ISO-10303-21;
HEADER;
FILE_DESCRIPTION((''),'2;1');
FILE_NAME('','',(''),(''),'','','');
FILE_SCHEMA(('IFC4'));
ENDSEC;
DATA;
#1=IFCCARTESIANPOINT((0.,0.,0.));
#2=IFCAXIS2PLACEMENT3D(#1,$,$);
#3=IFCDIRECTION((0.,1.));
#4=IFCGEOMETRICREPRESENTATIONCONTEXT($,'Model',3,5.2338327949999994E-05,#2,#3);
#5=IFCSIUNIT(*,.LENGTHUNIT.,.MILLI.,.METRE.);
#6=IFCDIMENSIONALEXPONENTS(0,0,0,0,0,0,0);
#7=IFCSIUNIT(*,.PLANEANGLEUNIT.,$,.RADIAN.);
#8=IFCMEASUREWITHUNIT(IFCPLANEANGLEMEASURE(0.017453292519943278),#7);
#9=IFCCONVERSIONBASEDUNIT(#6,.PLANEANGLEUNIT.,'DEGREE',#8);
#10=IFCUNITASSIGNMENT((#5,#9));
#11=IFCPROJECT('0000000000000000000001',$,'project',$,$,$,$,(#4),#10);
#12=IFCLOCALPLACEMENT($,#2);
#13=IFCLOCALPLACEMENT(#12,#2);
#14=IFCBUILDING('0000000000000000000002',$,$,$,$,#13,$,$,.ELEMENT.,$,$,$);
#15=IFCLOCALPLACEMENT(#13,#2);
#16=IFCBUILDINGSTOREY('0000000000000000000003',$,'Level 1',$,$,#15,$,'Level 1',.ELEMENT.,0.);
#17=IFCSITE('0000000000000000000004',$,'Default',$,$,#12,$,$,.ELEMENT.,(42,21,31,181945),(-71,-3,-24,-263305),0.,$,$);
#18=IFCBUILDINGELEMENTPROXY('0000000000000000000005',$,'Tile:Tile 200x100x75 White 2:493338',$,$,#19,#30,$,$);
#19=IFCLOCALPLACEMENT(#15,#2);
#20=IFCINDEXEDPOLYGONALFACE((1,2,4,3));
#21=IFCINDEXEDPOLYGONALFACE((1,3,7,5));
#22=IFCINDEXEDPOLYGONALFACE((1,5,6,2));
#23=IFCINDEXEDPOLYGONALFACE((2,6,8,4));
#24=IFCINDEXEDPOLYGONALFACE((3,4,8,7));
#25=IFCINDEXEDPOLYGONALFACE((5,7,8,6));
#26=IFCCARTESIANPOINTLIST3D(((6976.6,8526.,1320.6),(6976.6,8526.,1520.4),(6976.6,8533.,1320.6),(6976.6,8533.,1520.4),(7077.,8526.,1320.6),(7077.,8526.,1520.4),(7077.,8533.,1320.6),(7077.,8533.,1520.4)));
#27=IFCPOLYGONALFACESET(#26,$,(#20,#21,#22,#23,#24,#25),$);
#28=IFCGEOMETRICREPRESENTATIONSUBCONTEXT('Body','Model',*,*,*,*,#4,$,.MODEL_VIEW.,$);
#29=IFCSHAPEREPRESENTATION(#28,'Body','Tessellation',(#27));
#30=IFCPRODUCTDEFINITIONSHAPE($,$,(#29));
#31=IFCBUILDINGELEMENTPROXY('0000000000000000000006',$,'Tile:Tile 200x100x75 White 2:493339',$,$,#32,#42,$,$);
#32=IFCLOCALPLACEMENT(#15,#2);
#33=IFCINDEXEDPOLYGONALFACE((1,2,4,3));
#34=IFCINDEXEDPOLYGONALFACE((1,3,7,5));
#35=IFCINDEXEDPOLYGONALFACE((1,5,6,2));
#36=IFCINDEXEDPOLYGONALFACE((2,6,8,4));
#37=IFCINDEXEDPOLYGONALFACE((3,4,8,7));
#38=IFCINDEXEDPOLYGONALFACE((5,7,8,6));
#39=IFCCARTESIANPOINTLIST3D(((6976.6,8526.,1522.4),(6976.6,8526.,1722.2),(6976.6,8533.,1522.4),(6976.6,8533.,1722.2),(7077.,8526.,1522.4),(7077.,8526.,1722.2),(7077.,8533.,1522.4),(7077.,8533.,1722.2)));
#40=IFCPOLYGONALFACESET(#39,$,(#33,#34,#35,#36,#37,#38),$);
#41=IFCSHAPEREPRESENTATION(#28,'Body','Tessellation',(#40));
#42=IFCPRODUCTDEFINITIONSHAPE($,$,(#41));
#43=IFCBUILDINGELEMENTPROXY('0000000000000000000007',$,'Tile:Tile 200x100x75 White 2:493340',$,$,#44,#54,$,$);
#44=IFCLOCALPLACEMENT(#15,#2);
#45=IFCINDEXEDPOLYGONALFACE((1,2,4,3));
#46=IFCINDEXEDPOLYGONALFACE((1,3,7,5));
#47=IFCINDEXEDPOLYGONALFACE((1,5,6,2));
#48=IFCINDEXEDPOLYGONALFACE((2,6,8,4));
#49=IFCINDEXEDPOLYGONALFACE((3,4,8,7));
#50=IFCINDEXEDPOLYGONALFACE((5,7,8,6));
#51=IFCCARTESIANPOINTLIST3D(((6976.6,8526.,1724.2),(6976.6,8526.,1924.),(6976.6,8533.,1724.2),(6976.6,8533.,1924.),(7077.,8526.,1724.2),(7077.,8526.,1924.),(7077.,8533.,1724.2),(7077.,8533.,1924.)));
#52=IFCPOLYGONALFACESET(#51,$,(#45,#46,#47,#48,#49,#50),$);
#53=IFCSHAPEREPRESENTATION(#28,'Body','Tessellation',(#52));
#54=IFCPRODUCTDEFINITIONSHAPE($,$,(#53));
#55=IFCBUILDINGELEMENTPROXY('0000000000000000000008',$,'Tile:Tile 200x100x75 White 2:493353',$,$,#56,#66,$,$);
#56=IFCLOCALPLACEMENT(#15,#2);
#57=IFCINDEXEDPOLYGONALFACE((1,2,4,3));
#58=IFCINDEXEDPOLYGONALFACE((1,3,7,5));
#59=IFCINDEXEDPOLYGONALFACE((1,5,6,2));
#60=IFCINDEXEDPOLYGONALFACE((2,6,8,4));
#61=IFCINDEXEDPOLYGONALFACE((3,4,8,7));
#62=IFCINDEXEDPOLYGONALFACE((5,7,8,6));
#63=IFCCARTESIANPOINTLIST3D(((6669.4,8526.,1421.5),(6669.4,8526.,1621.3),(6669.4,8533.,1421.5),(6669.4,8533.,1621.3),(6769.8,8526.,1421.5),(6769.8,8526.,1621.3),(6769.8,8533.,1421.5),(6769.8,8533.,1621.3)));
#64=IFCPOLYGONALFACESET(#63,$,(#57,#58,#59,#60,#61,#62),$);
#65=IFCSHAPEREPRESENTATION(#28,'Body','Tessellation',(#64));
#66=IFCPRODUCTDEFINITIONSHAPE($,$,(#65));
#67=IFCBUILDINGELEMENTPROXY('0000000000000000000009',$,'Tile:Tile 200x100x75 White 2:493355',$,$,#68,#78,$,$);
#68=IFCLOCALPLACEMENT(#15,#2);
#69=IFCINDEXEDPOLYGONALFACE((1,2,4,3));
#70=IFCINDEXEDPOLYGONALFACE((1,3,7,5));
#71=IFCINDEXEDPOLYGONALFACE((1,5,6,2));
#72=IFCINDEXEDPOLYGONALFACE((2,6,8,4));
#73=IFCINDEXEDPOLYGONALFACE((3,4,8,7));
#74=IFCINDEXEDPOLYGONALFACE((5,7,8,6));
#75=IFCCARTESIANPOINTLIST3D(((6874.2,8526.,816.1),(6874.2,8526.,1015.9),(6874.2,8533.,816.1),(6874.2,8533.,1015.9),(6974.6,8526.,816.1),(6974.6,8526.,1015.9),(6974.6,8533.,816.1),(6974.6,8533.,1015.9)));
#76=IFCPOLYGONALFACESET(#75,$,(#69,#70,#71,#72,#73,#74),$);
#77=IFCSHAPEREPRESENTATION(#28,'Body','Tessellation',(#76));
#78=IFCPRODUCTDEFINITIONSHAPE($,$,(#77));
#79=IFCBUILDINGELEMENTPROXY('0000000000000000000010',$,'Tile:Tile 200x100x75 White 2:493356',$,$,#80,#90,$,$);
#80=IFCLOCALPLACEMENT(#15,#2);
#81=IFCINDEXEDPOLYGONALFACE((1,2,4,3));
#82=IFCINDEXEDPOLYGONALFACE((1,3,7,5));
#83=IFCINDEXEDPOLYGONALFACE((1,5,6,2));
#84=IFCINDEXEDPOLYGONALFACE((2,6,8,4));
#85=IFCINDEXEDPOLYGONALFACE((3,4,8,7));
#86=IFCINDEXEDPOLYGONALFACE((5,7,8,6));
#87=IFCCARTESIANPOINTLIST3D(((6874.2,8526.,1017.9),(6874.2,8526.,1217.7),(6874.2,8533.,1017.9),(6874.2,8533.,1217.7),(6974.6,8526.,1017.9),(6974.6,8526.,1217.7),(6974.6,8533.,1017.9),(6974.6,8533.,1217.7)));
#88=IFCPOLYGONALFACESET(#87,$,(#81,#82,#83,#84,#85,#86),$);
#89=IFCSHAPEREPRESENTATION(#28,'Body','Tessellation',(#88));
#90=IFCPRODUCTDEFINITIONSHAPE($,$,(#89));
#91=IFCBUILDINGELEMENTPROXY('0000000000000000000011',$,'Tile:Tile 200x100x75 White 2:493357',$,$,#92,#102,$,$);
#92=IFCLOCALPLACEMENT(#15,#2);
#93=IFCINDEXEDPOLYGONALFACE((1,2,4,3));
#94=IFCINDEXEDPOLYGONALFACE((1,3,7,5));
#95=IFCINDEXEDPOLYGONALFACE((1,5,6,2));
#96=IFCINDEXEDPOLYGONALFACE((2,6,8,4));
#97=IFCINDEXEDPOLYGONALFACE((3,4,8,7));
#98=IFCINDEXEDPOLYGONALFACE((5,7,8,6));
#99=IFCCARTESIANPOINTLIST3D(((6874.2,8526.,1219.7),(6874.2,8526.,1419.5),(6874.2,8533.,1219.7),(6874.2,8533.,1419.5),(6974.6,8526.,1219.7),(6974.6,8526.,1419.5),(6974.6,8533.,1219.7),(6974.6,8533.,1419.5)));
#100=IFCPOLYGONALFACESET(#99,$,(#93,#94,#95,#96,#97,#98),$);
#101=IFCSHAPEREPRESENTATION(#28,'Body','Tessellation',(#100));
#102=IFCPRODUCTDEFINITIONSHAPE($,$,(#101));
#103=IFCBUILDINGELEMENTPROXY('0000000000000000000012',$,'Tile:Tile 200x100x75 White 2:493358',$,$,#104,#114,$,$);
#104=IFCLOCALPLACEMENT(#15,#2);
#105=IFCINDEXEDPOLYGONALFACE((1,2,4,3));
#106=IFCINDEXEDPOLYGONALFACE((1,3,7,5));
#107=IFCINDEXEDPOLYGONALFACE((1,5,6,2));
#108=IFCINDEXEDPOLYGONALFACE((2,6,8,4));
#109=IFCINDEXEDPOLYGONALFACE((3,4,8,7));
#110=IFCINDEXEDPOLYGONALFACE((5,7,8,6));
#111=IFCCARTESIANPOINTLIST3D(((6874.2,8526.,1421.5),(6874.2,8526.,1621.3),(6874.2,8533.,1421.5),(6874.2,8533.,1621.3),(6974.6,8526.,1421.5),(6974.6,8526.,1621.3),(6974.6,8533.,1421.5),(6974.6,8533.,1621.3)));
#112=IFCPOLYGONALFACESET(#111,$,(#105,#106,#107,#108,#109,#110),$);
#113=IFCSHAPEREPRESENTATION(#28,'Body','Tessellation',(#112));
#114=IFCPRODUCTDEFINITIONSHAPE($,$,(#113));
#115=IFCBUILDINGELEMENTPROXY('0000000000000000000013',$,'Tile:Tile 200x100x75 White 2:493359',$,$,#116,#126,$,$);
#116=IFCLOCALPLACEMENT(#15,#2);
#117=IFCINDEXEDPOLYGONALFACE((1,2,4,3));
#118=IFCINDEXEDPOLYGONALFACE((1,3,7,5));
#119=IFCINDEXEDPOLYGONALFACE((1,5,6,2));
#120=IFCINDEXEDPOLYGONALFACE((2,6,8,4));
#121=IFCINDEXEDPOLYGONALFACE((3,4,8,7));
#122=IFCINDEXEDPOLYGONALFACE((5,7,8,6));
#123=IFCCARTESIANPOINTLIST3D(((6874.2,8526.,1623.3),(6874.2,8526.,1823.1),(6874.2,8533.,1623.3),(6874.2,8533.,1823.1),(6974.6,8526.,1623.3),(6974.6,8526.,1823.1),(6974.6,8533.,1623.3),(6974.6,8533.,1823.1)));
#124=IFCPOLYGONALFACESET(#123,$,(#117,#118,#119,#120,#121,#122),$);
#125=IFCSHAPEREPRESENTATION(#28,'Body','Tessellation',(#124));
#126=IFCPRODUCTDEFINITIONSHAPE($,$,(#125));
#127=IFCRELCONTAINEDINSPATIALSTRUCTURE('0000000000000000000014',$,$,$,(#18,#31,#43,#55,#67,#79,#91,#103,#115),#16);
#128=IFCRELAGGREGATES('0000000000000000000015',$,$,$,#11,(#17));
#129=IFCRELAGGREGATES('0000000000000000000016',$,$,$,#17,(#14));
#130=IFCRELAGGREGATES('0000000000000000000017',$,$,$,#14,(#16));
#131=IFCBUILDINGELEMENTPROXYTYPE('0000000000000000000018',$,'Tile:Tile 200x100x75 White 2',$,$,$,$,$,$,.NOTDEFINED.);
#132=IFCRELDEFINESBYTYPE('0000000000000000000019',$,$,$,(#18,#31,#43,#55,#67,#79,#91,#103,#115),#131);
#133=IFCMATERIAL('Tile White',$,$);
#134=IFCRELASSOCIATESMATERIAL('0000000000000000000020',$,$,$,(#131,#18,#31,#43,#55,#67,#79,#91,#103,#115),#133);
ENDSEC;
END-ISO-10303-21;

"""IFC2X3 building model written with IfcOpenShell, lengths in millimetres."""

from ifc_helpers import new_model, entity, si_unit, converted_unit, direction, frame, frame_2d, origin, place, context, subcontext, project, spatial, rectangle, extrude, source, transform, mapped, material, type_object, type_shapes, element, save


model = new_model("IFC2X3")

# Units and contexts
model_context = context("Model", 3, precision=5.2338327949999994e-05, world=origin(), true_north=direction((0.0, 1.0)))
body_context = subcontext(model_context, "Body", "Model", "MODEL_VIEW")
ifc_project = project(units=[si_unit("LENGTHUNIT", "METRE", prefix="MILLI"), converted_unit("PLANEANGLEUNIT", "DEGREE", entity("IfcPlaneAngleMeasure", 0.017453292519943278), si_unit("PLANEANGLEUNIT", "RADIAN"), dimensions=[0, 0, 0, 0, 0, 0, 0])], contexts=[model_context])

# Site, building, storey
site_placement = place(None, origin())
site = spatial("IfcSite", under=ifc_project, at=site_placement, Name="Default", CompositionType="ELEMENT", RefLatitude=(42, 21, 31, 181945), RefLongitude=(-71, -3, -24, -263305), RefElevation=0.0)
building_placement = place(site_placement, origin())
building = spatial("IfcBuilding", under=site, at=building_placement, CompositionType="ELEMENT")
storey_placement = place(building_placement, origin())
storey = spatial("IfcBuildingStorey", under=building, at=storey_placement, Name="Level 1", LongName="Level 1", CompositionType="ELEMENT", Elevation=0.0)

# Building element proxies
ifc_material = material(Name="Tile White")
building_element_proxy_type_1 = type_object("IfcBuildingElementProxyType", Name="Tile:Tile 200x100x75 White 2", PredefinedType="NOTDEFINED", material=ifc_material)
shared_shape_1 = source(origin(), body_context, "Body", "SweptSolid", [
    extrude(rectangle(XDim=199.8, YDim=100.4, at=frame_2d((0.0, 0.0), x_axis=(1.0, 0.0))), frame((-50.2, -99.9, 0.0), z_axis=(0.0, 0.0, 1.0), x_axis=(0.0, -1.0, 0.0)), (0.0, 0.0, 1.0), 7.0),
])
type_shapes(building_element_proxy_type_1, [shared_shape_1])
for number, where, z_axis, x_axis, name in (
    (1, (7077.0, 8533.0, 1520.4), (0.0, -1.0, 0.0), (1.0, 0.0, 0.0), "Tile:Tile 200x100x75 White 2:493338"),
    (2, (7077.0, 8533.0, 1722.2), (0.0, -1.0, 0.0), (1.0, 0.0, 0.0), "Tile:Tile 200x100x75 White 2:493339"),
    (3, (7077.0, 8533.0, 1924.0), (0.0, -1.0, 0.0), (1.0, 0.0, 0.0), "Tile:Tile 200x100x75 White 2:493340"),
    (4, (6769.8, 8533.0, 1621.3), (0.0, -1.0, 0.0), (1.0, 0.0, 0.0), "Tile:Tile 200x100x75 White 2:493353"),
    (5, (6974.6, 8533.0, 1015.9), (0.0, -1.0, 0.0), (1.0, 0.0, 0.0), "Tile:Tile 200x100x75 White 2:493355"),
    (6, (6974.6, 8533.0, 1217.7), (0.0, -1.0, 0.0), (1.0, 0.0, 0.0), "Tile:Tile 200x100x75 White 2:493356"),
    (7, (6974.6, 8533.0, 1419.5), (0.0, -1.0, 0.0), (1.0, 0.0, 0.0), "Tile:Tile 200x100x75 White 2:493357"),
    (8, (6974.6, 8533.0, 1621.3), (0.0, -1.0, 0.0), (1.0, 0.0, 0.0), "Tile:Tile 200x100x75 White 2:493358"),
    (9, (6974.6, 8533.0, 1823.1), (0.0, -1.0, 0.0), (1.0, 0.0, 0.0), "Tile:Tile 200x100x75 White 2:493359"),
):
    element("IfcBuildingElementProxy", number, at=place(storey_placement, frame(where, z_axis=z_axis, x_axis=x_axis)), inside=storey, type_object=building_element_proxy_type_1, material=ifc_material, Name=name, context=body_context, shape_type="MappedRepresentation", body=[
        mapped(shared_shape_1, transform((0.0, 0.0, 0.0), scale=1.0)),
    ])

save(model, "model.ifc")
